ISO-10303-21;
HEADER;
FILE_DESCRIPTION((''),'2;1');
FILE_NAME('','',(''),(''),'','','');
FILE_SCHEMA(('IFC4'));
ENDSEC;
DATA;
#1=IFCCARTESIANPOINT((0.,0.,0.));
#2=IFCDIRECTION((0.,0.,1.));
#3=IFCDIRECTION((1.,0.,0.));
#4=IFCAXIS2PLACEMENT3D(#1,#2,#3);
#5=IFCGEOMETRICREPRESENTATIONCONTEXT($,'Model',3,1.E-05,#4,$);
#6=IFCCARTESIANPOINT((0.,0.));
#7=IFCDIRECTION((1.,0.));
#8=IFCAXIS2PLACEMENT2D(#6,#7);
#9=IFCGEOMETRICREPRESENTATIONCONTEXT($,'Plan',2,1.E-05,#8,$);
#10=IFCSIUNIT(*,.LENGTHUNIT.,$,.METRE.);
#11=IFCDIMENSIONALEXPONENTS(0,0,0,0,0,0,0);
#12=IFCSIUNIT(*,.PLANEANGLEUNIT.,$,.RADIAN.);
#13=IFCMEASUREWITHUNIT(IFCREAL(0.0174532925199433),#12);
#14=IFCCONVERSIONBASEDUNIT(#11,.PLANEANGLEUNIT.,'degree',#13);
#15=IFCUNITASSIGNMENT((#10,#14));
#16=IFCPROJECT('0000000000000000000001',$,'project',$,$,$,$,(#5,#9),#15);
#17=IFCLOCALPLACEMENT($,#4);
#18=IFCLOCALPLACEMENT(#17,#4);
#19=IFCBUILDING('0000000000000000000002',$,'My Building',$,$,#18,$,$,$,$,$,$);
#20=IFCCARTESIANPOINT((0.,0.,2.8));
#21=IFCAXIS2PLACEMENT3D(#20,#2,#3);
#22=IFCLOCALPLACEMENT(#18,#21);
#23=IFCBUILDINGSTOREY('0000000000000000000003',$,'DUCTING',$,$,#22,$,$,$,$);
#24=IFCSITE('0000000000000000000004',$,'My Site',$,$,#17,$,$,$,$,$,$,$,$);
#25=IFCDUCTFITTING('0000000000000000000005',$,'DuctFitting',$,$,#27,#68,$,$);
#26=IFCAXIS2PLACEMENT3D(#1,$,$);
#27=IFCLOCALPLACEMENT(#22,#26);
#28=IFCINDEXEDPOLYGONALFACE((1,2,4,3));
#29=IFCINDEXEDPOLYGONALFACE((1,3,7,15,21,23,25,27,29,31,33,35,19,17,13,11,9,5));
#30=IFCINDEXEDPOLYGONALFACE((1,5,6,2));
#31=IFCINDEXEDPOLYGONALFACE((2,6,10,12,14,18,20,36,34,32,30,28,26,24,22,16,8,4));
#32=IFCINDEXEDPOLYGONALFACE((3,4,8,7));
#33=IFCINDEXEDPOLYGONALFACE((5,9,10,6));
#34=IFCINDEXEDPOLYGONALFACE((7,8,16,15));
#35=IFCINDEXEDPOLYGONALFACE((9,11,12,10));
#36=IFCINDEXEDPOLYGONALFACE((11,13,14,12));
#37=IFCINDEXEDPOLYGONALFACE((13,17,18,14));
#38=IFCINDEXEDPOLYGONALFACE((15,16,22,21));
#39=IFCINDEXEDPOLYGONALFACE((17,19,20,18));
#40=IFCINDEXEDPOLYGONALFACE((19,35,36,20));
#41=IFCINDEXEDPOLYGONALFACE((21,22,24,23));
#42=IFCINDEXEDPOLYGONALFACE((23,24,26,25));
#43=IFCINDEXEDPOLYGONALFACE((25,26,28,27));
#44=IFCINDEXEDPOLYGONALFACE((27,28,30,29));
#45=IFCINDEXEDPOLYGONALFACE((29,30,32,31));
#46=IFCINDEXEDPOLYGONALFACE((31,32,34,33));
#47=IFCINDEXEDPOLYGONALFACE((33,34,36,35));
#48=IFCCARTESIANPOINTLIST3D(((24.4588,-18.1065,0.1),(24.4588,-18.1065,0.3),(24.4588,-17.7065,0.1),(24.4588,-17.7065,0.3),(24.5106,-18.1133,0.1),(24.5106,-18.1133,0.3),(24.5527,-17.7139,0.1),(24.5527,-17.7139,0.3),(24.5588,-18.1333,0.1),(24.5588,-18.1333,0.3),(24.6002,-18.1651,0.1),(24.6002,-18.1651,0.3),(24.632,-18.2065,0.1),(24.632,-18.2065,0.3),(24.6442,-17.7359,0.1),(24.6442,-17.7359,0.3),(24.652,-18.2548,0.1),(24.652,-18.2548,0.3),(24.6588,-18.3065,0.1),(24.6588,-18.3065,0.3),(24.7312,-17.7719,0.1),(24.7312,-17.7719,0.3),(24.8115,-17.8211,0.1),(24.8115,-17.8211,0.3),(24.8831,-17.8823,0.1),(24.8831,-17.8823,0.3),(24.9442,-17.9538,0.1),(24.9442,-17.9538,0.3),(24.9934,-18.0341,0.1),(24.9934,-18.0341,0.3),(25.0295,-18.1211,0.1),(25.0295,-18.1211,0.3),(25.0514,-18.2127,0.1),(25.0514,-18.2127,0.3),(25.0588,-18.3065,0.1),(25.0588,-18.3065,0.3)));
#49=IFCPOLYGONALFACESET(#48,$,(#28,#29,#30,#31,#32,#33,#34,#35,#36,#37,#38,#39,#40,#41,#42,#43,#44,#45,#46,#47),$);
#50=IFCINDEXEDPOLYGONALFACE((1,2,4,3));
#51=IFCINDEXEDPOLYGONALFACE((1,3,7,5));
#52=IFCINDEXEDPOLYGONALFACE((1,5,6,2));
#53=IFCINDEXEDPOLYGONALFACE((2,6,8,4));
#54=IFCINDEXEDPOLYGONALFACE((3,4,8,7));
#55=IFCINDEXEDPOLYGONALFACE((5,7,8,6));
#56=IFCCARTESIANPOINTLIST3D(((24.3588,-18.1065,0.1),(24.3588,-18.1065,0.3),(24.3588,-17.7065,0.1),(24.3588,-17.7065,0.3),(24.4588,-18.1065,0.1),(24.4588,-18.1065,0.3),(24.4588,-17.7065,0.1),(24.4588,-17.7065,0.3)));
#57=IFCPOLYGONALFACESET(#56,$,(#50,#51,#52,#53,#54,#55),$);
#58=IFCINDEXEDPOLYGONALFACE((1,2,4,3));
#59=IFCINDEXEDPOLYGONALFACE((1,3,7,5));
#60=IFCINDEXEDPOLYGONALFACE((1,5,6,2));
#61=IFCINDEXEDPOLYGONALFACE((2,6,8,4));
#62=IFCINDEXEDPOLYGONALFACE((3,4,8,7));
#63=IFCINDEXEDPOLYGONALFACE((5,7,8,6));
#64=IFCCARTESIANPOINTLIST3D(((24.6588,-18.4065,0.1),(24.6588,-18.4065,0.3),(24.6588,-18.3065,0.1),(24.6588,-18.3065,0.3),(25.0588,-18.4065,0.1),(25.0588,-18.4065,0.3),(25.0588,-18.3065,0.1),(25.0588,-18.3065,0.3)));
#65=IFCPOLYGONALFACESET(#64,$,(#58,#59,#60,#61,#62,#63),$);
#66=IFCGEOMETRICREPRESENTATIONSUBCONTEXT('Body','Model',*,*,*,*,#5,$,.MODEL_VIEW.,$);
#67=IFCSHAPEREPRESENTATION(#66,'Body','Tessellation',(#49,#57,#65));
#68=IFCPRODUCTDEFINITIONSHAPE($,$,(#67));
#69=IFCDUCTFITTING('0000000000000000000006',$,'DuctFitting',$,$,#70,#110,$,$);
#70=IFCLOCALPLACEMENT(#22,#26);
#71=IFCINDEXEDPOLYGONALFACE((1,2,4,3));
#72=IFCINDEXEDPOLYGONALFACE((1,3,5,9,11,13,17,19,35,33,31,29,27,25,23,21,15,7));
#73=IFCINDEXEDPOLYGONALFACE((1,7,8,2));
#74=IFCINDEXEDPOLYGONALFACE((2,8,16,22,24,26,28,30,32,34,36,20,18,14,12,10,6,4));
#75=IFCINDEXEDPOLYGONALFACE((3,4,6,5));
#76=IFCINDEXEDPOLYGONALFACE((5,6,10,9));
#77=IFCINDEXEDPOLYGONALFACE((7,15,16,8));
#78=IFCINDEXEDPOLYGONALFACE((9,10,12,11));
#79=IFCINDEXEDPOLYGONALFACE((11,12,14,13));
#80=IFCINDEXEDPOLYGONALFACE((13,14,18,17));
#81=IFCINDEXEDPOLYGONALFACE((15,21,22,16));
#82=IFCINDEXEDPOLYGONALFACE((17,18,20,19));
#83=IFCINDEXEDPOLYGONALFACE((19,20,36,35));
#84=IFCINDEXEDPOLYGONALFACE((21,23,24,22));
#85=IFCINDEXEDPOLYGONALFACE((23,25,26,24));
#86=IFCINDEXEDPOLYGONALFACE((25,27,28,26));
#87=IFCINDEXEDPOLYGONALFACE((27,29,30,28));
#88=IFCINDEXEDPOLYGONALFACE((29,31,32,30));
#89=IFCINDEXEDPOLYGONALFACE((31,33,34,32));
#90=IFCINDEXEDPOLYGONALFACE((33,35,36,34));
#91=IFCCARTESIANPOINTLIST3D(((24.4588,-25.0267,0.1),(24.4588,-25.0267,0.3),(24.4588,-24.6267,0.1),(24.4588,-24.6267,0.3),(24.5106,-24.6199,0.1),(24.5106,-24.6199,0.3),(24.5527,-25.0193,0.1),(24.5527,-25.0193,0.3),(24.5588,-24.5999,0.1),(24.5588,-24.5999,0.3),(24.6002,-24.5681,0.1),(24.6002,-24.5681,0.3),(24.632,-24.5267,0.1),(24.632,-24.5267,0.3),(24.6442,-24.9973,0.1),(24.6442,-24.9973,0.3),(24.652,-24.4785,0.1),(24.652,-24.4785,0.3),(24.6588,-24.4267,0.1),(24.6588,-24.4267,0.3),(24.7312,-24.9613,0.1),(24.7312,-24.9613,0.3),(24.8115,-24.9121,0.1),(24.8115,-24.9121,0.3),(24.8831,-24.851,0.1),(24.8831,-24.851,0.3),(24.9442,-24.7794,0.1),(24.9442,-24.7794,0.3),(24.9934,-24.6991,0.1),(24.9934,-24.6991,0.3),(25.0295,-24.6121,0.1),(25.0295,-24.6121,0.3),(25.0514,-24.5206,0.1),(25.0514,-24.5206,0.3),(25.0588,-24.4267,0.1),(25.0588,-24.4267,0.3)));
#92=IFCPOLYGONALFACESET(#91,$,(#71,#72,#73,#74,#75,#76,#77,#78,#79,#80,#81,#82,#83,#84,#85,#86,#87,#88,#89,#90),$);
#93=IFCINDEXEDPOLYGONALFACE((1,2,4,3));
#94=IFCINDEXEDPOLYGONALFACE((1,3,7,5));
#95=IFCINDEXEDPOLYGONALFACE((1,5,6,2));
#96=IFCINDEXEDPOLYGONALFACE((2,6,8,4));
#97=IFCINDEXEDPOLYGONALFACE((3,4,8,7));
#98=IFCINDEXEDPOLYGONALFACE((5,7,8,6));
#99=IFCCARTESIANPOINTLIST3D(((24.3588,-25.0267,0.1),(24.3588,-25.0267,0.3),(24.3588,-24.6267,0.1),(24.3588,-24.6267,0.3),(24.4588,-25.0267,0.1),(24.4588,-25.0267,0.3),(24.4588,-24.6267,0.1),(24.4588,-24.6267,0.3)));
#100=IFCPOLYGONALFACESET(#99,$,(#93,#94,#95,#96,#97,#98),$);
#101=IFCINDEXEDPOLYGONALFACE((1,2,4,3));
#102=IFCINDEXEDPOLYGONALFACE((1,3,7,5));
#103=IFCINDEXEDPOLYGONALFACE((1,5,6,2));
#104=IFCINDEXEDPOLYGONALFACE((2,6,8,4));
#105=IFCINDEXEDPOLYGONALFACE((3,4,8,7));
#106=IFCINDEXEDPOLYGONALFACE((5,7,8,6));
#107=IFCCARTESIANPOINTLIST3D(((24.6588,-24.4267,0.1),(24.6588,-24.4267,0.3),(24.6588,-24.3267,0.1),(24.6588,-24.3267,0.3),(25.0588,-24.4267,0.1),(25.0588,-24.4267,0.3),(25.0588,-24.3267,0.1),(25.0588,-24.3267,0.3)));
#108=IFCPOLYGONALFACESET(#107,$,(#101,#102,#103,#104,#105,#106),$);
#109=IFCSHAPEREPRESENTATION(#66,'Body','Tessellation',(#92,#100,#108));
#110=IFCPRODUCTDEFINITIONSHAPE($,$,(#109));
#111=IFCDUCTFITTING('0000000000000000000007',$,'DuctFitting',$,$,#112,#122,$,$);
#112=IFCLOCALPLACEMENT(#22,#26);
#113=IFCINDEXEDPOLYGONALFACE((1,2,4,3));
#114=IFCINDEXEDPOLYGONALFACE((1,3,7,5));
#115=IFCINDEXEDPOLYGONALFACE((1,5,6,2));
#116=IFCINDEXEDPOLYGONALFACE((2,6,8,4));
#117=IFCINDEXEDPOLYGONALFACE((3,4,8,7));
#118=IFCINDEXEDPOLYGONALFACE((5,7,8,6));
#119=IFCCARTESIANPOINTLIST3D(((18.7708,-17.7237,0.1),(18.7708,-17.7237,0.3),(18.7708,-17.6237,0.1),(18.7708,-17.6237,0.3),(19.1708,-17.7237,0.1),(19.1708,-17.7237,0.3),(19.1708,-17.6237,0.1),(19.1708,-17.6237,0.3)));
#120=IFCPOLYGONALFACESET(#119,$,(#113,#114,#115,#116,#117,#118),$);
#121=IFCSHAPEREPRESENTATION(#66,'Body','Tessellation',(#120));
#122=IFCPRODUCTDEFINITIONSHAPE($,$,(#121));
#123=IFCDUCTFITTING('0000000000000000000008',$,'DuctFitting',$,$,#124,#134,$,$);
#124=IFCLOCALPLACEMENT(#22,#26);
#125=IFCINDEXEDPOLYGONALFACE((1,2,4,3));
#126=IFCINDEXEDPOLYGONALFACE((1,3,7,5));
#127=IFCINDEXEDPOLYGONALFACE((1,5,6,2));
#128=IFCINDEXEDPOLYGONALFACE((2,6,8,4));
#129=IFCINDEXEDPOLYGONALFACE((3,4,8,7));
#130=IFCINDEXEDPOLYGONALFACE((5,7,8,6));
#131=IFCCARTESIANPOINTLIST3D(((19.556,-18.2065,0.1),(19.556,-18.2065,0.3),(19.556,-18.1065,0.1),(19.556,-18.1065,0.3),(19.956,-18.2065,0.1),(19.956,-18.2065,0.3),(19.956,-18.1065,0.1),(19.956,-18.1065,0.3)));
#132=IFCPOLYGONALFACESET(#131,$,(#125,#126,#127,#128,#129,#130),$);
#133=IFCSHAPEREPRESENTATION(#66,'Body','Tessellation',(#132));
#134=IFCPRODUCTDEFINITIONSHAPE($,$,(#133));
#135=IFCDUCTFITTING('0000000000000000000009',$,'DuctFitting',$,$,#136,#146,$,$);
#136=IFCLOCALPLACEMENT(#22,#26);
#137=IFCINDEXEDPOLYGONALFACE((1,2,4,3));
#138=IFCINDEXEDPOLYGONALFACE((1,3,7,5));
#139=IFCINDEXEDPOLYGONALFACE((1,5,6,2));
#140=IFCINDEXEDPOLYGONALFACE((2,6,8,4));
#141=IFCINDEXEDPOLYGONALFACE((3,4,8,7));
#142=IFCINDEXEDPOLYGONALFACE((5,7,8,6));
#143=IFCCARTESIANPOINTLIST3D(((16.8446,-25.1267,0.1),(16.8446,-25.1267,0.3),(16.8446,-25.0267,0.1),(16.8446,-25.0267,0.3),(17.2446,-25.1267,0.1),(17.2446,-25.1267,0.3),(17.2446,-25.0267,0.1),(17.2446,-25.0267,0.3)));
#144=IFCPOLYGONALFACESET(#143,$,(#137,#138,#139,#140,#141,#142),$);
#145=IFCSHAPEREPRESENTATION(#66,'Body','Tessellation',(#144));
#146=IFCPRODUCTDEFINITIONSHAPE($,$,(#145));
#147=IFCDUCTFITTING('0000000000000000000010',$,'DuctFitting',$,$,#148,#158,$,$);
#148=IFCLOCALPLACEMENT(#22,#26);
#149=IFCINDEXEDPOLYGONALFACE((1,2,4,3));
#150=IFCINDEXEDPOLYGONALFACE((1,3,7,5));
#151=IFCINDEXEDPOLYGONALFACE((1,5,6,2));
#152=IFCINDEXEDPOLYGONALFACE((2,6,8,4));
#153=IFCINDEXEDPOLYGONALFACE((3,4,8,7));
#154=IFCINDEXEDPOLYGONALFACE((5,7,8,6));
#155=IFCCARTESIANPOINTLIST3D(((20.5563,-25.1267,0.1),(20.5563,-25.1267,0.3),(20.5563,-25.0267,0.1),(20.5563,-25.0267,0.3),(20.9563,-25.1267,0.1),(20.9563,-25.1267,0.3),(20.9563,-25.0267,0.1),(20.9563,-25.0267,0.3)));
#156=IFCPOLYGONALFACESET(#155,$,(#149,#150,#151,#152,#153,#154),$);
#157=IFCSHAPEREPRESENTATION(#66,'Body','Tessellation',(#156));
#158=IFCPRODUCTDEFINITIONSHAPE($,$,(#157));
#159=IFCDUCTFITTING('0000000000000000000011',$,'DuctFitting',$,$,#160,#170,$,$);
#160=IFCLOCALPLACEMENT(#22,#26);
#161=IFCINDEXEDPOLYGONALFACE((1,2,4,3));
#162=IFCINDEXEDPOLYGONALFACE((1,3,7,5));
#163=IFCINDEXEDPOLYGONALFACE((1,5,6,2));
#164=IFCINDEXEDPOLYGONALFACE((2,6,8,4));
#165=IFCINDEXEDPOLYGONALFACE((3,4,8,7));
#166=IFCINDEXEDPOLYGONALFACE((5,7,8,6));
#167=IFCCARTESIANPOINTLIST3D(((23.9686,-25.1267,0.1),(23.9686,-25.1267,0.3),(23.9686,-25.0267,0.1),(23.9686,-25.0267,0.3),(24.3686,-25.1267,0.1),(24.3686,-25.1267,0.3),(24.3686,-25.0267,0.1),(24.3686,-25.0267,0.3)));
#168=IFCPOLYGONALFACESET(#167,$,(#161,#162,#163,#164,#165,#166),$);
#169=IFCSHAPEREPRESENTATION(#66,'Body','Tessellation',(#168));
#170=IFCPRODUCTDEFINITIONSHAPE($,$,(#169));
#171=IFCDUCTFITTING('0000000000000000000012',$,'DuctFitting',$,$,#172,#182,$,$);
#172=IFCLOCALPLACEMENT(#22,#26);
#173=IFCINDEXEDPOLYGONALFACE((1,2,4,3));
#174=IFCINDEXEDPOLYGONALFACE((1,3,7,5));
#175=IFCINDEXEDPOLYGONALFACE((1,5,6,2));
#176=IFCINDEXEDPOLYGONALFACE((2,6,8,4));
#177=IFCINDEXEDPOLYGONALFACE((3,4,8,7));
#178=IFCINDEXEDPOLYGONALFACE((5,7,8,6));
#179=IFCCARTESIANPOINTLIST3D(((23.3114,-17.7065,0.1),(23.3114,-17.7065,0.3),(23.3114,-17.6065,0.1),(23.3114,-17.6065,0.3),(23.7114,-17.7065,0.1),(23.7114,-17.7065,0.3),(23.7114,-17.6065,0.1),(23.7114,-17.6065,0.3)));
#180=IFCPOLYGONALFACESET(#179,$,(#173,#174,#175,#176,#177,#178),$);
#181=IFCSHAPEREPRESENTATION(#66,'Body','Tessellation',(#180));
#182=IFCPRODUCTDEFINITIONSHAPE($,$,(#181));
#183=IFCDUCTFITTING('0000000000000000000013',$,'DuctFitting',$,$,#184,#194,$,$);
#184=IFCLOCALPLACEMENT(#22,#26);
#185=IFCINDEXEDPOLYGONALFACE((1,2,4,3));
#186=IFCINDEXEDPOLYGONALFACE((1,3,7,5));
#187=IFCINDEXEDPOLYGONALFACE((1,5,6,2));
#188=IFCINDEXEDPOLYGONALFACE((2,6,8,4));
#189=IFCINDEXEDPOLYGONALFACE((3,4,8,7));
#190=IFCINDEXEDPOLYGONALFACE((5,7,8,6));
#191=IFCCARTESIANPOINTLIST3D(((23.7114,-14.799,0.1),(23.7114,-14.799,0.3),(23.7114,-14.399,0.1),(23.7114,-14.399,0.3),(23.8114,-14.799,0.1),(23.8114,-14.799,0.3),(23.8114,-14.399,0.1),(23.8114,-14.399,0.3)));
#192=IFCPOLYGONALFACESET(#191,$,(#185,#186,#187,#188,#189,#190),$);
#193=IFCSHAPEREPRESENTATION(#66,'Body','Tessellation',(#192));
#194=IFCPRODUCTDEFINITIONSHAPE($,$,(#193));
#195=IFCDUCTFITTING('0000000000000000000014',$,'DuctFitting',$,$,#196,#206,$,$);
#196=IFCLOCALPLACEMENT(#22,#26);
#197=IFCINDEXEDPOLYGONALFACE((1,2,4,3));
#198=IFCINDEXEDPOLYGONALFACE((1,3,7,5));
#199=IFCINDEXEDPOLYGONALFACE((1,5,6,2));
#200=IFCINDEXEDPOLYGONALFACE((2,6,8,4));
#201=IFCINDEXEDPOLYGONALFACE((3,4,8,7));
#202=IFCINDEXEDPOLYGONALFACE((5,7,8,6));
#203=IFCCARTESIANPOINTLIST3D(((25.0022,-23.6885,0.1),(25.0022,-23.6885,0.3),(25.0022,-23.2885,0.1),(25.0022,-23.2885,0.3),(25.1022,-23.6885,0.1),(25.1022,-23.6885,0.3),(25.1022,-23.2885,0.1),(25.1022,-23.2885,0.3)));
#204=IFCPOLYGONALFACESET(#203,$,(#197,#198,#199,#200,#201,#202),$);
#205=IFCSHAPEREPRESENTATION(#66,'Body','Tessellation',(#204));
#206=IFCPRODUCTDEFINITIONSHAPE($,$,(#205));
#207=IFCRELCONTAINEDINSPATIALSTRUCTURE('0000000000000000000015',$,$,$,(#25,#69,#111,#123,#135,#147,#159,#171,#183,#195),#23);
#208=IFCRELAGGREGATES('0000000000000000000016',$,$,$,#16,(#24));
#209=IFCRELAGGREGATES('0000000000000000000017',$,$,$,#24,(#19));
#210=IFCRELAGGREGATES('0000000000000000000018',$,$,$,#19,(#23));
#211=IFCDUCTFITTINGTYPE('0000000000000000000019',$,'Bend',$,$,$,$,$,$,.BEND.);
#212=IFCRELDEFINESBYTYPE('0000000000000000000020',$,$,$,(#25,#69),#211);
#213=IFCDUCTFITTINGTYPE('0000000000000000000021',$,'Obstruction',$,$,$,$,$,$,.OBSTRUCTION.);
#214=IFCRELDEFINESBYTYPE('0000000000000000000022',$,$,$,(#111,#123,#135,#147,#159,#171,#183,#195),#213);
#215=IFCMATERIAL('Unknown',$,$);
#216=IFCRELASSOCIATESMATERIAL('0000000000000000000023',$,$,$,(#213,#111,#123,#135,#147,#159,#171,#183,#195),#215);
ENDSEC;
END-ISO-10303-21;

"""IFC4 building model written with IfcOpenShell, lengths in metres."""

from ifc_helpers import new_model, entity, si_unit, converted_unit, frame, origin_with_axes, origin_2d_with_axis, place, context, subcontext, project, spatial, line, arc, indexed_curve, rectangle, outline, extrude, source, transform, mapped, material, material_profile, profile_set, profile_usage, type_object, type_shapes, element, save


model = new_model("IFC4")

# Units and contexts
model_context = context("Model", 3, precision=1e-05, world=origin_with_axes())
plan_context = context("Plan", 2, precision=1e-05, world=origin_2d_with_axis())
body_context = subcontext(model_context, "Body", "Model", "MODEL_VIEW")
ifc_project = project(units=[si_unit("LENGTHUNIT", "METRE"), converted_unit("PLANEANGLEUNIT", "degree", entity("IfcReal", 0.0174532925199433), si_unit("PLANEANGLEUNIT", "RADIAN"), dimensions=[0, 0, 0, 0, 0, 0, 0])], contexts=[model_context, plan_context])

# Site, building, storey
site_placement = place(None, origin_with_axes())
site = spatial("IfcSite", under=ifc_project, at=site_placement, Name="My Site")
building_placement = place(site_placement, origin_with_axes())
building = spatial("IfcBuilding", under=site, at=building_placement, Name="My Building")
storey_placement = place(building_placement, frame((0.0, 0.0, 2.8), z_axis=(0.0, 0.0, 1.0), x_axis=(1.0, 0.0, 0.0)))
storey = spatial("IfcBuildingStorey", under=building, at=storey_placement, Name="DUCTING")

# Shared definitions
ifc_material = material(Name="Unknown")

# Duct fittings
duct_fitting_type_1 = type_object("IfcDuctFittingType", Name="Bend", PredefinedType="BEND")
shared_shape = source(origin_with_axes(), body_context, "Body", "SweptSolid", [
    extrude(outline(indexed_curve([(-0.2, 0.0), (-0.2586, -0.1414), (-0.4, -0.2), (-0.4, -0.6), (0.0243, -0.4243), (0.2, 0.0)], segments=[arc(1, 2, 3), line(3, 4), arc(4, 5, 6), line(6, 1)])), frame((0.0, -0.1, -0.1), z_axis=(0.0, -1.0, 0.0), x_axis=(1.0, 0.0, 0.0)), (0.0, 0.0, -1.0), 0.2),
    extrude(rectangle(XDim=0.4, YDim=0.2), origin_with_axes(), (0.0, 0.0, -1.0), 0.1),
    extrude(rectangle(XDim=0.4, YDim=0.2), frame((-0.4, 0.0, -0.5), z_axis=(-1.0, 0.0, 0.0), x_axis=(0.0, 0.0, -1.0)), (0.0, 0.0, 1.0), 0.1),
])
type_shapes(duct_fitting_type_1, [shared_shape])
for number, where, z_axis, x_axis, name in (
    (1, (24.3588, -17.9065, 0.2), (-1.0, 0.0, 0.0), (0.0, 1.0, 0.0), "DuctFitting"),
    (2, (24.3588, -24.8267, 0.2), (-1.0, 0.0, 0.0), (0.0, -1.0, 0.0), "DuctFitting"),
):
    element("IfcDuctFitting", number, at=place(storey_placement, frame(where, z_axis=z_axis, x_axis=x_axis)), inside=storey, type_object=duct_fitting_type_1, Name=name, context=body_context, shape_type="MappedRepresentation", body=[
        mapped(shared_shape, transform((0.0, 0.0, 0.0), x_axis=(1.0, 0.0, 0.0), y_axis=(0.0, 1.0, 0.0), z_axis=(0.0, 0.0, 1.0), scale=1.0)),
    ])
ifc_material_profile_1 = material_profile(ifc_material, rectangle(XDim=0.4, YDim=0.2))
ifc_profile_set_1 = profile_set([ifc_material_profile_1])
ifc_profile_usage_1 = profile_usage(ifc_profile_set_1, cardinal=5)
duct_fitting_type_2 = type_object("IfcDuctFittingType", Name="Obstruction", PredefinedType="OBSTRUCTION", material=ifc_profile_set_1)
duct_fitting_1_placement = place(storey_placement, frame((18.9708, -17.7237, 0.2), z_axis=(0.0, 1.0, 0.0), x_axis=(-1.0, 0.0, 0.0)))
element("IfcDuctFitting", 3, at=duct_fitting_1_placement, inside=storey, type_object=duct_fitting_type_2, material=ifc_profile_usage_1, Name="DuctFitting", context=body_context, shape_type="SweptSolid", body=[
    extrude(rectangle(XDim=0.4, YDim=0.2), origin_with_axes(), (0.0, 0.0, 1.0), 0.1),
])
ifc_profile_usage_2 = profile_usage(ifc_profile_set_1, cardinal=5)
duct_fitting_2_placement = place(storey_placement, frame((19.756, -18.1065, 0.2), z_axis=(0.0, -1.0, 0.0), x_axis=(1.0, 0.0, 0.0)))
element("IfcDuctFitting", 4, at=duct_fitting_2_placement, inside=storey, type_object=duct_fitting_type_2, material=ifc_profile_usage_2, Name="DuctFitting", context=body_context, shape_type="SweptSolid", body=[
    extrude(rectangle(XDim=0.4, YDim=0.2), origin_with_axes(), (0.0, 0.0, 1.0), 0.1),
])
ifc_profile_usage_3 = profile_usage(ifc_profile_set_1, cardinal=5)
duct_fitting_3_placement = place(storey_placement, frame((17.0446, -25.0267, 0.2), z_axis=(0.0, -1.0, 0.0), x_axis=(1.0, 0.0, 0.0)))
element("IfcDuctFitting", 5, at=duct_fitting_3_placement, inside=storey, type_object=duct_fitting_type_2, material=ifc_profile_usage_3, Name="DuctFitting", context=body_context, shape_type="SweptSolid", body=[
    extrude(rectangle(XDim=0.4, YDim=0.2), origin_with_axes(), (0.0, 0.0, 1.0), 0.1),
])
ifc_profile_usage_4 = profile_usage(ifc_profile_set_1, cardinal=5)
duct_fitting_4_placement = place(storey_placement, frame((20.7563, -25.0267, 0.2), z_axis=(0.0, -1.0, 0.0), x_axis=(1.0, 0.0, 0.0)))
element("IfcDuctFitting", 6, at=duct_fitting_4_placement, inside=storey, type_object=duct_fitting_type_2, material=ifc_profile_usage_4, Name="DuctFitting", context=body_context, shape_type="SweptSolid", body=[
    extrude(rectangle(XDim=0.4, YDim=0.2), origin_with_axes(), (0.0, 0.0, 1.0), 0.1),
])
ifc_profile_usage_5 = profile_usage(ifc_profile_set_1, cardinal=5)
duct_fitting_5_placement = place(storey_placement, frame((24.1686, -25.0267, 0.2), z_axis=(0.0, -1.0, 0.0), x_axis=(1.0, 0.0, 0.0)))
element("IfcDuctFitting", 7, at=duct_fitting_5_placement, inside=storey, type_object=duct_fitting_type_2, material=ifc_profile_usage_5, Name="DuctFitting", context=body_context, shape_type="SweptSolid", body=[
    extrude(rectangle(XDim=0.4, YDim=0.2), origin_with_axes(), (0.0, 0.0, 1.0), 0.1),
])
ifc_profile_usage_6 = profile_usage(ifc_profile_set_1, cardinal=5)
duct_fitting_6_placement = place(storey_placement, frame((23.5114, -17.7065, 0.2), z_axis=(0.0, 1.0, 0.0), x_axis=(-1.0, 0.0, 0.0)))
element("IfcDuctFitting", 8, at=duct_fitting_6_placement, inside=storey, type_object=duct_fitting_type_2, material=ifc_profile_usage_6, Name="DuctFitting", context=body_context, shape_type="SweptSolid", body=[
    extrude(rectangle(XDim=0.4, YDim=0.2), origin_with_axes(), (0.0, 0.0, 1.0), 0.1),
])
ifc_profile_usage_7 = profile_usage(ifc_profile_set_1, cardinal=5)
duct_fitting_7_placement = place(storey_placement, frame((23.7114, -14.599, 0.2), z_axis=(1.0, 0.0, 0.0), x_axis=(0.0, 1.0, 0.0)))
element("IfcDuctFitting", 9, at=duct_fitting_7_placement, inside=storey, type_object=duct_fitting_type_2, material=ifc_profile_usage_7, Name="DuctFitting", context=body_context, shape_type="SweptSolid", body=[
    extrude(rectangle(XDim=0.4, YDim=0.2), origin_with_axes(), (0.0, 0.0, 1.0), 0.1),
])
ifc_profile_usage_8 = profile_usage(ifc_profile_set_1, cardinal=5)
duct_fitting_8_placement = place(storey_placement, frame((25.0022, -23.4885, 0.2), z_axis=(1.0, 0.0, 0.0), x_axis=(0.0, 1.0, 0.0)))
element("IfcDuctFitting", 10, at=duct_fitting_8_placement, inside=storey, type_object=duct_fitting_type_2, material=ifc_profile_usage_8, Name="DuctFitting", context=body_context, shape_type="SweptSolid", body=[
    extrude(rectangle(XDim=0.4, YDim=0.2), origin_with_axes(), (0.0, 0.0, 1.0), 0.1),
])

save(model, "model.ifc")
